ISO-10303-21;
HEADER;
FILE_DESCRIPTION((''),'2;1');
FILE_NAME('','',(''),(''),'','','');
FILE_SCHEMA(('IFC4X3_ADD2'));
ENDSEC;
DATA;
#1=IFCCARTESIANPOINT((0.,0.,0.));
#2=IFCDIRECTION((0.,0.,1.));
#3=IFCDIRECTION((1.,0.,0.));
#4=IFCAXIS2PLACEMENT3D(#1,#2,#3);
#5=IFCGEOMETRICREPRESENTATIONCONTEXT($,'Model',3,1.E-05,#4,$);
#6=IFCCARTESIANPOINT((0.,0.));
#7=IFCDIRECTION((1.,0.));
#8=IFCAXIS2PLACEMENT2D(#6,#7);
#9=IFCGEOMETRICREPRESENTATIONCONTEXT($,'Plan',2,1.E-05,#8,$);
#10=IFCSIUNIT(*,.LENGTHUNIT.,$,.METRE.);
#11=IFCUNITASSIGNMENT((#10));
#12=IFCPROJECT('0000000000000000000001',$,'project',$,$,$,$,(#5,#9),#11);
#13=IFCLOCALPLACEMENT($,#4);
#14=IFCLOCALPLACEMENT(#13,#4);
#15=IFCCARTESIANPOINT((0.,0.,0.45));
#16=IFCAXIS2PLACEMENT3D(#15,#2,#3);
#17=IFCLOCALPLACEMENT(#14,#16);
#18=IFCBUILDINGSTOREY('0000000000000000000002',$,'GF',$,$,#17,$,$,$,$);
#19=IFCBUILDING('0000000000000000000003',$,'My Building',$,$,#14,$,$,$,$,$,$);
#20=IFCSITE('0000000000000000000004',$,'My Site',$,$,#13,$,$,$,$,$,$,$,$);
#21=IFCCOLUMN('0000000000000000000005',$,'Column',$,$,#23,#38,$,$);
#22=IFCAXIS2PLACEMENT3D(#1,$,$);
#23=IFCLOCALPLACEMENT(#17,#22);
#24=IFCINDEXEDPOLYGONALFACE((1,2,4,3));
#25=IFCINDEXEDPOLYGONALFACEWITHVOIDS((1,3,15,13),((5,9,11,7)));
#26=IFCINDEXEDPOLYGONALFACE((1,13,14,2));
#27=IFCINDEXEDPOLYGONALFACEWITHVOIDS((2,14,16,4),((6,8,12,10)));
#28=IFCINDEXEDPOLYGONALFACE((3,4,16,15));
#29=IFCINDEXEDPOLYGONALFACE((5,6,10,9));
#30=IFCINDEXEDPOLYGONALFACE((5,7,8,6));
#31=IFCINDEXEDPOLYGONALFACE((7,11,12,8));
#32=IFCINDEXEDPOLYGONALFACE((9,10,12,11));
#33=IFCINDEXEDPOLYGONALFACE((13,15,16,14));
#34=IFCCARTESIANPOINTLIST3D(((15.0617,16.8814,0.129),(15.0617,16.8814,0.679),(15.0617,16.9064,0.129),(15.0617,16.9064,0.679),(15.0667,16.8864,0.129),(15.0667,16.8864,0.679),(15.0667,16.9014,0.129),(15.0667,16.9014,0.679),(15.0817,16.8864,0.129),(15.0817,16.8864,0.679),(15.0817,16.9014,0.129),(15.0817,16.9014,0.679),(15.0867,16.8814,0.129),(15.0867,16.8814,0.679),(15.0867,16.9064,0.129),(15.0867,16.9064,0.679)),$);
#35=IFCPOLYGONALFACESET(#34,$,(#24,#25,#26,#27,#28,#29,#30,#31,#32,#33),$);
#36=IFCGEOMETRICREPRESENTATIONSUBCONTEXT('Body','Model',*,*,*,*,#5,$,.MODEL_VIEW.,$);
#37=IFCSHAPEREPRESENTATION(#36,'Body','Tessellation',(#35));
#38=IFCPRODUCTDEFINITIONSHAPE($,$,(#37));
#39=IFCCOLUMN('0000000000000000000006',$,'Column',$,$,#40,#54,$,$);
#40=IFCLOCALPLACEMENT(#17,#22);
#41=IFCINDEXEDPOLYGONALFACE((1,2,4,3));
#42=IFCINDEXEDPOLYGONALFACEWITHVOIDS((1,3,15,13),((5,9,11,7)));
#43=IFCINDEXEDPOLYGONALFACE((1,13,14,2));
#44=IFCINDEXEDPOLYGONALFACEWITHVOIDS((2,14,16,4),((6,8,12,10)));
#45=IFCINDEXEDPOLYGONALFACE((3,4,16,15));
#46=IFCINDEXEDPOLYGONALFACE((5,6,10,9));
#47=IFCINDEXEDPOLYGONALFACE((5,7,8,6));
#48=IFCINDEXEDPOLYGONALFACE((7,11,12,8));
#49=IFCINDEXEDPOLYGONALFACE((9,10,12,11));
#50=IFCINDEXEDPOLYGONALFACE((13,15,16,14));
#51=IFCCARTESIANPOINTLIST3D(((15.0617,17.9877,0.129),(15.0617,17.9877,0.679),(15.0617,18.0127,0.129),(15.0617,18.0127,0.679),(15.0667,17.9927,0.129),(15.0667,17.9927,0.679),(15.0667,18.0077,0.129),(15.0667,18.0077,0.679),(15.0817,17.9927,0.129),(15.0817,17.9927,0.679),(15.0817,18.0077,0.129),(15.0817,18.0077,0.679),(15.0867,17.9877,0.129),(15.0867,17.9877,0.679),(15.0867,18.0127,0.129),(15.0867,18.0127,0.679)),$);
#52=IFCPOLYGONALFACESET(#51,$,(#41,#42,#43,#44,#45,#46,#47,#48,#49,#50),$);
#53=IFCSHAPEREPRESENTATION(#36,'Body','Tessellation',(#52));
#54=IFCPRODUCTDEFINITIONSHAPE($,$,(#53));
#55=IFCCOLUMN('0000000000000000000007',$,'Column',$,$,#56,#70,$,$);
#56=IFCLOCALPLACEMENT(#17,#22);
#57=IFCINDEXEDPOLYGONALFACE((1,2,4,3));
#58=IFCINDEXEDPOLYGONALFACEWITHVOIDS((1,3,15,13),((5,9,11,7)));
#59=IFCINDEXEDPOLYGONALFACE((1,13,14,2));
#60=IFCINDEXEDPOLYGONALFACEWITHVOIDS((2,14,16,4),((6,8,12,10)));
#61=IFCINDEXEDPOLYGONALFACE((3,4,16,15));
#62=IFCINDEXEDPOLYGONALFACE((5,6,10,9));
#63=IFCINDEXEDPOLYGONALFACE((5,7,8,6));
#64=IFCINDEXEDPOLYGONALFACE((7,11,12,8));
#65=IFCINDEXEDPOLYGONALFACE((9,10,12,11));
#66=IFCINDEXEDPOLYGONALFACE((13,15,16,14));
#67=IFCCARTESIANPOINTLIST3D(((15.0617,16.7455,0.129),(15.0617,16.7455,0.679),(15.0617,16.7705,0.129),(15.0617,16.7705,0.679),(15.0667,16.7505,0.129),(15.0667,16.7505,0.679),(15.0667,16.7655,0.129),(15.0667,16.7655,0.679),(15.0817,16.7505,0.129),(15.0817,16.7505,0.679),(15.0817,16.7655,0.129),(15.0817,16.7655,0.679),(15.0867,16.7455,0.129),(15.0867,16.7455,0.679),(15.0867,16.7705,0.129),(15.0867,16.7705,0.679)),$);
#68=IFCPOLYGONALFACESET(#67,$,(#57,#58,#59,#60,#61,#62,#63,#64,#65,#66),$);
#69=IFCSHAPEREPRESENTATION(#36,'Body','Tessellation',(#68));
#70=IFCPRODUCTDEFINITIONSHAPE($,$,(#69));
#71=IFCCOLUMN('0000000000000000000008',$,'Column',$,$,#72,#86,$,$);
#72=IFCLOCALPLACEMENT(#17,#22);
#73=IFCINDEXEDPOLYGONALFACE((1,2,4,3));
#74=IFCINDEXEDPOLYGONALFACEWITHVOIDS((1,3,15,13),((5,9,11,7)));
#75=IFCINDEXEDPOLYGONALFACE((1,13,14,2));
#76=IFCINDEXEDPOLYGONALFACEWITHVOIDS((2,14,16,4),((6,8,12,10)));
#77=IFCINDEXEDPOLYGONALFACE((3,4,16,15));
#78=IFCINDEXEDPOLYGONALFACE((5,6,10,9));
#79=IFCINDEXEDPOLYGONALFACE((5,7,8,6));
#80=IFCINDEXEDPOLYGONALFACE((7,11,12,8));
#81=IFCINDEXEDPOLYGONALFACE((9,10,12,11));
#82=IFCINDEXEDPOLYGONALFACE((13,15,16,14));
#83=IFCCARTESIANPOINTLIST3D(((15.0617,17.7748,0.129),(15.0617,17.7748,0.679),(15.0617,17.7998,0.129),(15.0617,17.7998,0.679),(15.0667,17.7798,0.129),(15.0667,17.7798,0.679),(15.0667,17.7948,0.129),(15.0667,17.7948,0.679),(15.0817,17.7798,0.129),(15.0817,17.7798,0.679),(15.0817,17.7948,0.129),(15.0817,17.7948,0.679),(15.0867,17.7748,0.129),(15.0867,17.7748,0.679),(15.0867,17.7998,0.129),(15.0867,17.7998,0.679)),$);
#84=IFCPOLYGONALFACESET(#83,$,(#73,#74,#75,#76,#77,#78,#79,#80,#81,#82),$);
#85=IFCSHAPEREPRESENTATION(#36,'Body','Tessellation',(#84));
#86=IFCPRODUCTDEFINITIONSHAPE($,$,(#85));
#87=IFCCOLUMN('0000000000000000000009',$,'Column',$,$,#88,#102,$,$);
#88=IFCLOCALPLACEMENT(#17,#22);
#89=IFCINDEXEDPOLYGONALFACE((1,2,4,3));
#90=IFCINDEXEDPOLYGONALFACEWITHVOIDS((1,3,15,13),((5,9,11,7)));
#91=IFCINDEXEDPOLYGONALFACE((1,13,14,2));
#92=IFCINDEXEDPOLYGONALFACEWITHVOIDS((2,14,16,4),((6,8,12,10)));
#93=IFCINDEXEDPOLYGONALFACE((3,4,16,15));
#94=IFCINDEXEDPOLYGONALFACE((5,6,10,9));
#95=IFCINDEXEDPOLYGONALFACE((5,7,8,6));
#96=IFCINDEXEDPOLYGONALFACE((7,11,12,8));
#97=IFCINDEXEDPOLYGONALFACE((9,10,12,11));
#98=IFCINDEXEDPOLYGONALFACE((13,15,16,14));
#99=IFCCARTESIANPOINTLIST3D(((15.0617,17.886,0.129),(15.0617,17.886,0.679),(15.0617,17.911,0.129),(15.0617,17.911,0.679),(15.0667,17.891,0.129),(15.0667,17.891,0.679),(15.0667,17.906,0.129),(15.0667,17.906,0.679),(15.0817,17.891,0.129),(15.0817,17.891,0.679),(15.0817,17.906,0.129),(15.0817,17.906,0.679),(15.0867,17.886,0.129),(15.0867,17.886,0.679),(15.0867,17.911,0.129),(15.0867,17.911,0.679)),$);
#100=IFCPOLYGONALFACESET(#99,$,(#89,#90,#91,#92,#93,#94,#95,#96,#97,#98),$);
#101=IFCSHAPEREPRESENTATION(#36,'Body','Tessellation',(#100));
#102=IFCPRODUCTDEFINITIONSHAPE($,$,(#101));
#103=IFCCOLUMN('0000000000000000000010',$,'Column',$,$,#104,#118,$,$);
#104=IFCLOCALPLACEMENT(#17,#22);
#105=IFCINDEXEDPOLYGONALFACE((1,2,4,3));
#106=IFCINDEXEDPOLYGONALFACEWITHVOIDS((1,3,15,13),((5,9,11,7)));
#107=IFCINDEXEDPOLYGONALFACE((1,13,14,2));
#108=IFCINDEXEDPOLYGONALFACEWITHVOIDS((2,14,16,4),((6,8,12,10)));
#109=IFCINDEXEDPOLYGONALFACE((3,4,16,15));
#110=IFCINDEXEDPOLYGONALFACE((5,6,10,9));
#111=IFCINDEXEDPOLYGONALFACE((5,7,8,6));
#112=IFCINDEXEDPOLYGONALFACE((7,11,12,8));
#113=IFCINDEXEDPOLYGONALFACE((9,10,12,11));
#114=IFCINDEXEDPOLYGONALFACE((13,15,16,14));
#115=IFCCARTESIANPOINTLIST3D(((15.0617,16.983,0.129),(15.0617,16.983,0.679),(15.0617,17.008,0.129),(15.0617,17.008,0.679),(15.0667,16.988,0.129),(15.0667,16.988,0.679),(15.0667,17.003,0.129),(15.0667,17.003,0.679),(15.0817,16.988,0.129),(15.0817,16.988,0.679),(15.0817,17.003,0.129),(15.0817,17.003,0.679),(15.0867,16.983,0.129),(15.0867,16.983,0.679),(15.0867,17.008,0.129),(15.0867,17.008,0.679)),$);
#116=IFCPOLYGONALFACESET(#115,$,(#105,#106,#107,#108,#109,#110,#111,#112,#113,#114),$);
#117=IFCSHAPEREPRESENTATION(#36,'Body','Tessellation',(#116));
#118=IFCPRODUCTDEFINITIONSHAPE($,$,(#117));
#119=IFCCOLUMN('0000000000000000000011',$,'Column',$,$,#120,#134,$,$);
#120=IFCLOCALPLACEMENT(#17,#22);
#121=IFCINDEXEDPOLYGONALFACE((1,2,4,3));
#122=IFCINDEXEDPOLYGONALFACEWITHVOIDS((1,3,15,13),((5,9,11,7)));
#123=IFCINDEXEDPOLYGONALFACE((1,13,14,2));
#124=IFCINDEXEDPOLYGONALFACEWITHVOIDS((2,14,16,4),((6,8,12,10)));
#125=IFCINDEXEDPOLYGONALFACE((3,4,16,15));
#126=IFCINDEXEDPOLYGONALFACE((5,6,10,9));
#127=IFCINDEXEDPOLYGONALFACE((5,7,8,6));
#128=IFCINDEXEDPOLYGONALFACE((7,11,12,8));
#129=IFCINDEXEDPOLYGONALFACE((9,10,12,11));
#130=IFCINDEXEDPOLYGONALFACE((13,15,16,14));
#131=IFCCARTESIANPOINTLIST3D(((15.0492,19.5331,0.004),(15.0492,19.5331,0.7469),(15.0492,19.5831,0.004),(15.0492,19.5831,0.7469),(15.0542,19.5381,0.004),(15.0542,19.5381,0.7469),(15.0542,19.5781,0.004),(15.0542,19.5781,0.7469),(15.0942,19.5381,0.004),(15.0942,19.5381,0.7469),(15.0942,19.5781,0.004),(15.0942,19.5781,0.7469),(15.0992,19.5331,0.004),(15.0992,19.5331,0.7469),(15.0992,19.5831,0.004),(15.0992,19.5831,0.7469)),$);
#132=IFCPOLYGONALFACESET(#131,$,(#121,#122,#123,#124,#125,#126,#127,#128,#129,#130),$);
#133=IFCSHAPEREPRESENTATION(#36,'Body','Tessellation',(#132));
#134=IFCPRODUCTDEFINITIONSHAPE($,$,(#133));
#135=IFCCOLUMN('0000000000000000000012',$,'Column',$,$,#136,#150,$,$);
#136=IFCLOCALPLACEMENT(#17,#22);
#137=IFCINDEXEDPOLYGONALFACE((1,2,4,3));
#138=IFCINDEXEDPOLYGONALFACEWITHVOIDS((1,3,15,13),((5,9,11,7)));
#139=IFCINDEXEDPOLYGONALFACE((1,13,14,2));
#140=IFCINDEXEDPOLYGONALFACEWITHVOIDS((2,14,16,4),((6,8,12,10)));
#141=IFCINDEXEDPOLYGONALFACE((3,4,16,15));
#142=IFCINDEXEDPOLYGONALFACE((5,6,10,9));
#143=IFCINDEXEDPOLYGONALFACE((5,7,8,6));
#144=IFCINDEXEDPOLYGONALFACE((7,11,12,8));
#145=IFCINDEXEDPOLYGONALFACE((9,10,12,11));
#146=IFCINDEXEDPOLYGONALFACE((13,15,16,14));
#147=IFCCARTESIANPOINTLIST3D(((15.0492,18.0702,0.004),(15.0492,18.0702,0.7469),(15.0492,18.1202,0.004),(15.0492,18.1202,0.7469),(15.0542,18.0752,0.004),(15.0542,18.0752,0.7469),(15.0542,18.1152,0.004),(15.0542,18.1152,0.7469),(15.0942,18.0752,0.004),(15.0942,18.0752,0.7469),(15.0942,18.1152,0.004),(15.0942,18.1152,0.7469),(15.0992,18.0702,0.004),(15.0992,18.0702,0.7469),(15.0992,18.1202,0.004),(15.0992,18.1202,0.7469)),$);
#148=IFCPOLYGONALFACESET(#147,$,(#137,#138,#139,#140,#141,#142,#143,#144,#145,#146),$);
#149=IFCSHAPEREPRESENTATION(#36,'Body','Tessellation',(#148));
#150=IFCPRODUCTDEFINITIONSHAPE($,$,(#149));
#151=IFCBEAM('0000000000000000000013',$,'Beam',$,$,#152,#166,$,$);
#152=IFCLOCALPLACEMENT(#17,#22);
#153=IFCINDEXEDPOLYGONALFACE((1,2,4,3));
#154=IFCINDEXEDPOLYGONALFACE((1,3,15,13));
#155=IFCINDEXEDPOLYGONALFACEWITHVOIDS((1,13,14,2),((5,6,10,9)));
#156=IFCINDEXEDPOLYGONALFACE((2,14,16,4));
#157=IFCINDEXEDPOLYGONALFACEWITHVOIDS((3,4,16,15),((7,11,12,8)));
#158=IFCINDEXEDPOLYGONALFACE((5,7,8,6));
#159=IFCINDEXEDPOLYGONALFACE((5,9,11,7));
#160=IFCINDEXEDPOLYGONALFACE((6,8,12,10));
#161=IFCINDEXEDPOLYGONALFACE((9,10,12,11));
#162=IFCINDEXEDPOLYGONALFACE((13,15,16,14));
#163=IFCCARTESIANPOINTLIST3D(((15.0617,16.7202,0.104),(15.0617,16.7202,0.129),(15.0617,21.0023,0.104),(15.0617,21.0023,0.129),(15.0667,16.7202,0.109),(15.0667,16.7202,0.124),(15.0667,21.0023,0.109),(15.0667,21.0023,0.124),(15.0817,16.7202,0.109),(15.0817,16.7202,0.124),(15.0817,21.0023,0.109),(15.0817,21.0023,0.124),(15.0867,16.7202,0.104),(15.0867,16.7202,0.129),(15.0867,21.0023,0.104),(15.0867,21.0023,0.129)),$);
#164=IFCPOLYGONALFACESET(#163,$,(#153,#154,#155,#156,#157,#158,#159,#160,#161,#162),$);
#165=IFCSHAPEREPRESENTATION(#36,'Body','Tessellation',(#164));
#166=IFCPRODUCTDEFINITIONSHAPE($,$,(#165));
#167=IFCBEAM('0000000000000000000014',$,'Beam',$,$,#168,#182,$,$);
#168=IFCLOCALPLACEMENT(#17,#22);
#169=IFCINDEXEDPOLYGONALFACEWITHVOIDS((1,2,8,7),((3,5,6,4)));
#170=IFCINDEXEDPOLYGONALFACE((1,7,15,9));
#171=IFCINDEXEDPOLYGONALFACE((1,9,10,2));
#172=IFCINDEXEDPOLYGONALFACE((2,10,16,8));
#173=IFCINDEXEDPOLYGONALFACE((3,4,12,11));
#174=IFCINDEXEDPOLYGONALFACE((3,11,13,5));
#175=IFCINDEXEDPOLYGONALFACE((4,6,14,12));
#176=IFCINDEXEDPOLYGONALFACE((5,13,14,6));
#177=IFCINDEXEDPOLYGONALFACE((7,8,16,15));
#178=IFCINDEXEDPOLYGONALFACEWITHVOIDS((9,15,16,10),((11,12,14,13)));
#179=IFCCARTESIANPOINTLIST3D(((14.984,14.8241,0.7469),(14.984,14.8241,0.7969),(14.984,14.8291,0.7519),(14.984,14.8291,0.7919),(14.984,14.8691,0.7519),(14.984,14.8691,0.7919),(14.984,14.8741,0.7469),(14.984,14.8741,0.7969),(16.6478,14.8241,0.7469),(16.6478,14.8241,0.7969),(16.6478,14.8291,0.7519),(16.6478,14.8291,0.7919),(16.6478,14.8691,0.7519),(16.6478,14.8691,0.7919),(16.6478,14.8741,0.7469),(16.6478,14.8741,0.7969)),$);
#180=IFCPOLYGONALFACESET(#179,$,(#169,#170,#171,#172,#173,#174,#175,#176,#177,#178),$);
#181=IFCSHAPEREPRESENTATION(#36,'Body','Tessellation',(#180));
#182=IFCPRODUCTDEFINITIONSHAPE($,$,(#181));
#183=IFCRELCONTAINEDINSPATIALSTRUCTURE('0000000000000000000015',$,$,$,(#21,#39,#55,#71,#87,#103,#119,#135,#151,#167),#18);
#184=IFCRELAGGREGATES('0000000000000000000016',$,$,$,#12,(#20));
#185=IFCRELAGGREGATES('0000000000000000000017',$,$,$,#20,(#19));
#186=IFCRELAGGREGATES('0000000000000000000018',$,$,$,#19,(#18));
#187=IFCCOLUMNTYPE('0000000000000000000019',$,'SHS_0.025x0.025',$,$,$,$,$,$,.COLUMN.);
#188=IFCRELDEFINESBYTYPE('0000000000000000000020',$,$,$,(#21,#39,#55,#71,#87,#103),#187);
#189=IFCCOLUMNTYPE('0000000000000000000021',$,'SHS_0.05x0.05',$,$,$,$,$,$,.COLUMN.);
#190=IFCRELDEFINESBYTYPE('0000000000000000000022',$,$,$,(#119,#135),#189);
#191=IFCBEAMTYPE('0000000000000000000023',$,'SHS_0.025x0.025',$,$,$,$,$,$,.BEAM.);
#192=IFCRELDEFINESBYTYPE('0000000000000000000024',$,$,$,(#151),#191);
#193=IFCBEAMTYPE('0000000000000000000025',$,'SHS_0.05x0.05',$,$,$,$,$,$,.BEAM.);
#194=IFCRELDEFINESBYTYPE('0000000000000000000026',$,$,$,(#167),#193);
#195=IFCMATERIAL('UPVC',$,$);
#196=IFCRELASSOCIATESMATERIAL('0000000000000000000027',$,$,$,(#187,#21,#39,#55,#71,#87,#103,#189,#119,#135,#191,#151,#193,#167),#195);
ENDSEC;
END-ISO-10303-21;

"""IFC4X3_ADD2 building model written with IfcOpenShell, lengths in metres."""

from ifc_helpers import new_model, si_unit, frame, origin_with_axes, origin_2d_with_axis, place, context, subcontext, project, spatial, hollow_rectangle, extrude, material, material_profile, profile_set, profile_usage, type_object, element, save


model = new_model("IFC4X3_ADD2")

# Units and contexts
model_context = context("Model", 3, precision=1e-05, world=origin_with_axes())
plan_context = context("Plan", 2, precision=1e-05, world=origin_2d_with_axis())
body_context_1 = subcontext(model_context, "Body", "Model", "MODEL_VIEW")
ifc_project = project(units=[si_unit("LENGTHUNIT", "METRE")], contexts=[model_context, plan_context])

# Site, building, storey
site_placement = place(None, origin_with_axes())
site = spatial("IfcSite", under=ifc_project, at=site_placement, Name="My Site")
building_placement = place(site_placement, origin_with_axes())
building = spatial("IfcBuilding", under=site, at=building_placement, Name="My Building")
storey_placement = place(building_placement, frame((0.0, 0.0, 0.45), z_axis=(0.0, 0.0, 1.0), x_axis=(1.0, 0.0, 0.0)))
storey = spatial("IfcBuildingStorey", under=building, at=storey_placement, Name="GF")

# Columns
ifc_material_1 = material(Name="UPVC")
ifc_material_profile_1 = material_profile(ifc_material_1, hollow_rectangle(XDim=0.025, YDim=0.025, WallThickness=0.005))
ifc_profile_set_1 = profile_set([ifc_material_profile_1])
column_type_1 = type_object("IfcColumnType", Name="SHS_0.025x0.025", PredefinedType="COLUMN", material=ifc_profile_set_1)
ifc_profile_usage_1 = profile_usage(ifc_profile_set_1)
column_1_placement = place(storey_placement, frame((15.0742, 16.8939, 0.129), z_axis=(0.0, 0.0, 1.0), x_axis=(0.0, -1.0, 0.0)))
element("IfcColumn", 1, at=column_1_placement, inside=storey, type_object=column_type_1, material=ifc_profile_usage_1, Name="Column", context=body_context_1, shape_type="SweptSolid", body=[
    extrude(hollow_rectangle(XDim=0.025, YDim=0.025, WallThickness=0.005), origin_with_axes(), (0.0, 0.0, 1.0), 0.55),
])
ifc_profile_usage_2 = profile_usage(ifc_profile_set_1)
column_2_placement = place(storey_placement, frame((15.0742, 18.0002, 0.129), z_axis=(0.0, 0.0, 1.0), x_axis=(0.0, -1.0, 0.0)))
element("IfcColumn", 2, at=column_2_placement, inside=storey, type_object=column_type_1, material=ifc_profile_usage_2, Name="Column", context=body_context_1, shape_type="SweptSolid", body=[
    extrude(hollow_rectangle(XDim=0.025, YDim=0.025, WallThickness=0.005), origin_with_axes(), (0.0, 0.0, 1.0), 0.55),
])
ifc_profile_usage_3 = profile_usage(ifc_profile_set_1)
column_3_placement = place(storey_placement, frame((15.0742, 16.758, 0.129), z_axis=(0.0, 0.0, 1.0), x_axis=(0.0, -1.0, 0.0)))
element("IfcColumn", 3, at=column_3_placement, inside=storey, type_object=column_type_1, material=ifc_profile_usage_3, Name="Column", context=body_context_1, shape_type="SweptSolid", body=[
    extrude(hollow_rectangle(XDim=0.025, YDim=0.025, WallThickness=0.005), origin_with_axes(), (0.0, 0.0, 1.0), 0.55),
])
ifc_profile_usage_4 = profile_usage(ifc_profile_set_1)
column_4_placement = place(storey_placement, frame((15.0742, 17.7873, 0.129), z_axis=(0.0, 0.0, 1.0), x_axis=(0.0, -1.0, 0.0)))
element("IfcColumn", 4, at=column_4_placement, inside=storey, type_object=column_type_1, material=ifc_profile_usage_4, Name="Column", context=body_context_1, shape_type="SweptSolid", body=[
    extrude(hollow_rectangle(XDim=0.025, YDim=0.025, WallThickness=0.005), origin_with_axes(), (0.0, 0.0, 1.0), 0.55),
])
ifc_profile_usage_5 = profile_usage(ifc_profile_set_1)
column_5_placement = place(storey_placement, frame((15.0742, 17.8985, 0.129), z_axis=(0.0, 0.0, 1.0), x_axis=(0.0, -1.0, 0.0)))
element("IfcColumn", 5, at=column_5_placement, inside=storey, type_object=column_type_1, material=ifc_profile_usage_5, Name="Column", context=body_context_1, shape_type="SweptSolid", body=[
    extrude(hollow_rectangle(XDim=0.025, YDim=0.025, WallThickness=0.005), origin_with_axes(), (0.0, 0.0, 1.0), 0.55),
])
ifc_profile_usage_6 = profile_usage(ifc_profile_set_1)
column_6_placement = place(storey_placement, frame((15.0742, 16.9955, 0.129), z_axis=(0.0, 0.0, 1.0), x_axis=(0.0, -1.0, 0.0)))
element("IfcColumn", 6, at=column_6_placement, inside=storey, type_object=column_type_1, material=ifc_profile_usage_6, Name="Column", context=body_context_1, shape_type="SweptSolid", body=[
    extrude(hollow_rectangle(XDim=0.025, YDim=0.025, WallThickness=0.005), origin_with_axes(), (0.0, 0.0, 1.0), 0.55),
])
ifc_material_profile_2 = material_profile(ifc_material_1, hollow_rectangle(XDim=0.05, YDim=0.05, WallThickness=0.005))
ifc_profile_set_2 = profile_set([ifc_material_profile_2])
ifc_profile_usage_7 = profile_usage(ifc_profile_set_2)
column_type_2 = type_object("IfcColumnType", Name="SHS_0.05x0.05", PredefinedType="COLUMN", material=ifc_profile_set_2)
column_7_placement = place(storey_placement, frame((15.0742, 19.5581, 0.004), z_axis=(0.0, 0.0, 1.0), x_axis=(0.0, -1.0, 0.0)))
element("IfcColumn", 7, at=column_7_placement, inside=storey, type_object=column_type_2, material=ifc_profile_usage_7, Name="Column", context=body_context_1, shape_type="SweptSolid", body=[
    extrude(hollow_rectangle(XDim=0.05, YDim=0.05, WallThickness=0.005), origin_with_axes(), (0.0, 0.0, 1.0), 0.7429),
])
ifc_profile_usage_8 = profile_usage(ifc_profile_set_2)
column_8_placement = place(storey_placement, frame((15.0742, 18.0952, 0.004), z_axis=(0.0, 0.0, 1.0), x_axis=(0.0, -1.0, 0.0)))
element("IfcColumn", 8, at=column_8_placement, inside=storey, type_object=column_type_2, material=ifc_profile_usage_8, Name="Column", context=body_context_1, shape_type="SweptSolid", body=[
    extrude(hollow_rectangle(XDim=0.05, YDim=0.05, WallThickness=0.005), origin_with_axes(), (0.0, 0.0, 1.0), 0.7429),
])

# Beams
ifc_material_profile_3 = material_profile(ifc_material_1, hollow_rectangle(XDim=0.025, YDim=0.025, WallThickness=0.005))
ifc_profile_set_3 = profile_set([ifc_material_profile_3])
ifc_profile_usage_9 = profile_usage(ifc_profile_set_3)
beam_type_1 = type_object("IfcBeamType", Name="SHS_0.025x0.025", PredefinedType="BEAM", material=ifc_profile_set_3)
beam_1_placement = place(storey_placement, frame((15.0742, 21.0023, 0.1165), z_axis=(0.0, -1.0, 0.0), x_axis=(1.0, 0.0, 0.0)))
element("IfcBeam", 9, at=beam_1_placement, inside=storey, type_object=beam_type_1, material=ifc_profile_usage_9, Name="Beam", context=body_context_1, shape_type="SweptSolid", body=[
    extrude(hollow_rectangle(XDim=0.025, YDim=0.025, WallThickness=0.005), origin_with_axes(), (0.0, 0.0, 1.0), 4.2821),
])
ifc_material_profile_4 = material_profile(ifc_material_1, hollow_rectangle(XDim=0.05, YDim=0.05, WallThickness=0.005))
ifc_profile_set_4 = profile_set([ifc_material_profile_4])
ifc_profile_usage_10 = profile_usage(ifc_profile_set_4)
beam_type_2 = type_object("IfcBeamType", Name="SHS_0.05x0.05", PredefinedType="BEAM", material=ifc_profile_set_4)
beam_2_placement = place(storey_placement, frame((14.984, 14.8491, 0.7719), z_axis=(1.0, 0.0, 0.0), x_axis=(0.0, 1.0, 0.0)))
element("IfcBeam", 10, at=beam_2_placement, inside=storey, type_object=beam_type_2, material=ifc_profile_usage_10, Name="Beam", context=body_context_1, shape_type="SweptSolid", body=[
    extrude(hollow_rectangle(XDim=0.05, YDim=0.05, WallThickness=0.005), origin_with_axes(), (0.0, 0.0, 1.0), 1.6638),
])

save(model, "model.ifc")
